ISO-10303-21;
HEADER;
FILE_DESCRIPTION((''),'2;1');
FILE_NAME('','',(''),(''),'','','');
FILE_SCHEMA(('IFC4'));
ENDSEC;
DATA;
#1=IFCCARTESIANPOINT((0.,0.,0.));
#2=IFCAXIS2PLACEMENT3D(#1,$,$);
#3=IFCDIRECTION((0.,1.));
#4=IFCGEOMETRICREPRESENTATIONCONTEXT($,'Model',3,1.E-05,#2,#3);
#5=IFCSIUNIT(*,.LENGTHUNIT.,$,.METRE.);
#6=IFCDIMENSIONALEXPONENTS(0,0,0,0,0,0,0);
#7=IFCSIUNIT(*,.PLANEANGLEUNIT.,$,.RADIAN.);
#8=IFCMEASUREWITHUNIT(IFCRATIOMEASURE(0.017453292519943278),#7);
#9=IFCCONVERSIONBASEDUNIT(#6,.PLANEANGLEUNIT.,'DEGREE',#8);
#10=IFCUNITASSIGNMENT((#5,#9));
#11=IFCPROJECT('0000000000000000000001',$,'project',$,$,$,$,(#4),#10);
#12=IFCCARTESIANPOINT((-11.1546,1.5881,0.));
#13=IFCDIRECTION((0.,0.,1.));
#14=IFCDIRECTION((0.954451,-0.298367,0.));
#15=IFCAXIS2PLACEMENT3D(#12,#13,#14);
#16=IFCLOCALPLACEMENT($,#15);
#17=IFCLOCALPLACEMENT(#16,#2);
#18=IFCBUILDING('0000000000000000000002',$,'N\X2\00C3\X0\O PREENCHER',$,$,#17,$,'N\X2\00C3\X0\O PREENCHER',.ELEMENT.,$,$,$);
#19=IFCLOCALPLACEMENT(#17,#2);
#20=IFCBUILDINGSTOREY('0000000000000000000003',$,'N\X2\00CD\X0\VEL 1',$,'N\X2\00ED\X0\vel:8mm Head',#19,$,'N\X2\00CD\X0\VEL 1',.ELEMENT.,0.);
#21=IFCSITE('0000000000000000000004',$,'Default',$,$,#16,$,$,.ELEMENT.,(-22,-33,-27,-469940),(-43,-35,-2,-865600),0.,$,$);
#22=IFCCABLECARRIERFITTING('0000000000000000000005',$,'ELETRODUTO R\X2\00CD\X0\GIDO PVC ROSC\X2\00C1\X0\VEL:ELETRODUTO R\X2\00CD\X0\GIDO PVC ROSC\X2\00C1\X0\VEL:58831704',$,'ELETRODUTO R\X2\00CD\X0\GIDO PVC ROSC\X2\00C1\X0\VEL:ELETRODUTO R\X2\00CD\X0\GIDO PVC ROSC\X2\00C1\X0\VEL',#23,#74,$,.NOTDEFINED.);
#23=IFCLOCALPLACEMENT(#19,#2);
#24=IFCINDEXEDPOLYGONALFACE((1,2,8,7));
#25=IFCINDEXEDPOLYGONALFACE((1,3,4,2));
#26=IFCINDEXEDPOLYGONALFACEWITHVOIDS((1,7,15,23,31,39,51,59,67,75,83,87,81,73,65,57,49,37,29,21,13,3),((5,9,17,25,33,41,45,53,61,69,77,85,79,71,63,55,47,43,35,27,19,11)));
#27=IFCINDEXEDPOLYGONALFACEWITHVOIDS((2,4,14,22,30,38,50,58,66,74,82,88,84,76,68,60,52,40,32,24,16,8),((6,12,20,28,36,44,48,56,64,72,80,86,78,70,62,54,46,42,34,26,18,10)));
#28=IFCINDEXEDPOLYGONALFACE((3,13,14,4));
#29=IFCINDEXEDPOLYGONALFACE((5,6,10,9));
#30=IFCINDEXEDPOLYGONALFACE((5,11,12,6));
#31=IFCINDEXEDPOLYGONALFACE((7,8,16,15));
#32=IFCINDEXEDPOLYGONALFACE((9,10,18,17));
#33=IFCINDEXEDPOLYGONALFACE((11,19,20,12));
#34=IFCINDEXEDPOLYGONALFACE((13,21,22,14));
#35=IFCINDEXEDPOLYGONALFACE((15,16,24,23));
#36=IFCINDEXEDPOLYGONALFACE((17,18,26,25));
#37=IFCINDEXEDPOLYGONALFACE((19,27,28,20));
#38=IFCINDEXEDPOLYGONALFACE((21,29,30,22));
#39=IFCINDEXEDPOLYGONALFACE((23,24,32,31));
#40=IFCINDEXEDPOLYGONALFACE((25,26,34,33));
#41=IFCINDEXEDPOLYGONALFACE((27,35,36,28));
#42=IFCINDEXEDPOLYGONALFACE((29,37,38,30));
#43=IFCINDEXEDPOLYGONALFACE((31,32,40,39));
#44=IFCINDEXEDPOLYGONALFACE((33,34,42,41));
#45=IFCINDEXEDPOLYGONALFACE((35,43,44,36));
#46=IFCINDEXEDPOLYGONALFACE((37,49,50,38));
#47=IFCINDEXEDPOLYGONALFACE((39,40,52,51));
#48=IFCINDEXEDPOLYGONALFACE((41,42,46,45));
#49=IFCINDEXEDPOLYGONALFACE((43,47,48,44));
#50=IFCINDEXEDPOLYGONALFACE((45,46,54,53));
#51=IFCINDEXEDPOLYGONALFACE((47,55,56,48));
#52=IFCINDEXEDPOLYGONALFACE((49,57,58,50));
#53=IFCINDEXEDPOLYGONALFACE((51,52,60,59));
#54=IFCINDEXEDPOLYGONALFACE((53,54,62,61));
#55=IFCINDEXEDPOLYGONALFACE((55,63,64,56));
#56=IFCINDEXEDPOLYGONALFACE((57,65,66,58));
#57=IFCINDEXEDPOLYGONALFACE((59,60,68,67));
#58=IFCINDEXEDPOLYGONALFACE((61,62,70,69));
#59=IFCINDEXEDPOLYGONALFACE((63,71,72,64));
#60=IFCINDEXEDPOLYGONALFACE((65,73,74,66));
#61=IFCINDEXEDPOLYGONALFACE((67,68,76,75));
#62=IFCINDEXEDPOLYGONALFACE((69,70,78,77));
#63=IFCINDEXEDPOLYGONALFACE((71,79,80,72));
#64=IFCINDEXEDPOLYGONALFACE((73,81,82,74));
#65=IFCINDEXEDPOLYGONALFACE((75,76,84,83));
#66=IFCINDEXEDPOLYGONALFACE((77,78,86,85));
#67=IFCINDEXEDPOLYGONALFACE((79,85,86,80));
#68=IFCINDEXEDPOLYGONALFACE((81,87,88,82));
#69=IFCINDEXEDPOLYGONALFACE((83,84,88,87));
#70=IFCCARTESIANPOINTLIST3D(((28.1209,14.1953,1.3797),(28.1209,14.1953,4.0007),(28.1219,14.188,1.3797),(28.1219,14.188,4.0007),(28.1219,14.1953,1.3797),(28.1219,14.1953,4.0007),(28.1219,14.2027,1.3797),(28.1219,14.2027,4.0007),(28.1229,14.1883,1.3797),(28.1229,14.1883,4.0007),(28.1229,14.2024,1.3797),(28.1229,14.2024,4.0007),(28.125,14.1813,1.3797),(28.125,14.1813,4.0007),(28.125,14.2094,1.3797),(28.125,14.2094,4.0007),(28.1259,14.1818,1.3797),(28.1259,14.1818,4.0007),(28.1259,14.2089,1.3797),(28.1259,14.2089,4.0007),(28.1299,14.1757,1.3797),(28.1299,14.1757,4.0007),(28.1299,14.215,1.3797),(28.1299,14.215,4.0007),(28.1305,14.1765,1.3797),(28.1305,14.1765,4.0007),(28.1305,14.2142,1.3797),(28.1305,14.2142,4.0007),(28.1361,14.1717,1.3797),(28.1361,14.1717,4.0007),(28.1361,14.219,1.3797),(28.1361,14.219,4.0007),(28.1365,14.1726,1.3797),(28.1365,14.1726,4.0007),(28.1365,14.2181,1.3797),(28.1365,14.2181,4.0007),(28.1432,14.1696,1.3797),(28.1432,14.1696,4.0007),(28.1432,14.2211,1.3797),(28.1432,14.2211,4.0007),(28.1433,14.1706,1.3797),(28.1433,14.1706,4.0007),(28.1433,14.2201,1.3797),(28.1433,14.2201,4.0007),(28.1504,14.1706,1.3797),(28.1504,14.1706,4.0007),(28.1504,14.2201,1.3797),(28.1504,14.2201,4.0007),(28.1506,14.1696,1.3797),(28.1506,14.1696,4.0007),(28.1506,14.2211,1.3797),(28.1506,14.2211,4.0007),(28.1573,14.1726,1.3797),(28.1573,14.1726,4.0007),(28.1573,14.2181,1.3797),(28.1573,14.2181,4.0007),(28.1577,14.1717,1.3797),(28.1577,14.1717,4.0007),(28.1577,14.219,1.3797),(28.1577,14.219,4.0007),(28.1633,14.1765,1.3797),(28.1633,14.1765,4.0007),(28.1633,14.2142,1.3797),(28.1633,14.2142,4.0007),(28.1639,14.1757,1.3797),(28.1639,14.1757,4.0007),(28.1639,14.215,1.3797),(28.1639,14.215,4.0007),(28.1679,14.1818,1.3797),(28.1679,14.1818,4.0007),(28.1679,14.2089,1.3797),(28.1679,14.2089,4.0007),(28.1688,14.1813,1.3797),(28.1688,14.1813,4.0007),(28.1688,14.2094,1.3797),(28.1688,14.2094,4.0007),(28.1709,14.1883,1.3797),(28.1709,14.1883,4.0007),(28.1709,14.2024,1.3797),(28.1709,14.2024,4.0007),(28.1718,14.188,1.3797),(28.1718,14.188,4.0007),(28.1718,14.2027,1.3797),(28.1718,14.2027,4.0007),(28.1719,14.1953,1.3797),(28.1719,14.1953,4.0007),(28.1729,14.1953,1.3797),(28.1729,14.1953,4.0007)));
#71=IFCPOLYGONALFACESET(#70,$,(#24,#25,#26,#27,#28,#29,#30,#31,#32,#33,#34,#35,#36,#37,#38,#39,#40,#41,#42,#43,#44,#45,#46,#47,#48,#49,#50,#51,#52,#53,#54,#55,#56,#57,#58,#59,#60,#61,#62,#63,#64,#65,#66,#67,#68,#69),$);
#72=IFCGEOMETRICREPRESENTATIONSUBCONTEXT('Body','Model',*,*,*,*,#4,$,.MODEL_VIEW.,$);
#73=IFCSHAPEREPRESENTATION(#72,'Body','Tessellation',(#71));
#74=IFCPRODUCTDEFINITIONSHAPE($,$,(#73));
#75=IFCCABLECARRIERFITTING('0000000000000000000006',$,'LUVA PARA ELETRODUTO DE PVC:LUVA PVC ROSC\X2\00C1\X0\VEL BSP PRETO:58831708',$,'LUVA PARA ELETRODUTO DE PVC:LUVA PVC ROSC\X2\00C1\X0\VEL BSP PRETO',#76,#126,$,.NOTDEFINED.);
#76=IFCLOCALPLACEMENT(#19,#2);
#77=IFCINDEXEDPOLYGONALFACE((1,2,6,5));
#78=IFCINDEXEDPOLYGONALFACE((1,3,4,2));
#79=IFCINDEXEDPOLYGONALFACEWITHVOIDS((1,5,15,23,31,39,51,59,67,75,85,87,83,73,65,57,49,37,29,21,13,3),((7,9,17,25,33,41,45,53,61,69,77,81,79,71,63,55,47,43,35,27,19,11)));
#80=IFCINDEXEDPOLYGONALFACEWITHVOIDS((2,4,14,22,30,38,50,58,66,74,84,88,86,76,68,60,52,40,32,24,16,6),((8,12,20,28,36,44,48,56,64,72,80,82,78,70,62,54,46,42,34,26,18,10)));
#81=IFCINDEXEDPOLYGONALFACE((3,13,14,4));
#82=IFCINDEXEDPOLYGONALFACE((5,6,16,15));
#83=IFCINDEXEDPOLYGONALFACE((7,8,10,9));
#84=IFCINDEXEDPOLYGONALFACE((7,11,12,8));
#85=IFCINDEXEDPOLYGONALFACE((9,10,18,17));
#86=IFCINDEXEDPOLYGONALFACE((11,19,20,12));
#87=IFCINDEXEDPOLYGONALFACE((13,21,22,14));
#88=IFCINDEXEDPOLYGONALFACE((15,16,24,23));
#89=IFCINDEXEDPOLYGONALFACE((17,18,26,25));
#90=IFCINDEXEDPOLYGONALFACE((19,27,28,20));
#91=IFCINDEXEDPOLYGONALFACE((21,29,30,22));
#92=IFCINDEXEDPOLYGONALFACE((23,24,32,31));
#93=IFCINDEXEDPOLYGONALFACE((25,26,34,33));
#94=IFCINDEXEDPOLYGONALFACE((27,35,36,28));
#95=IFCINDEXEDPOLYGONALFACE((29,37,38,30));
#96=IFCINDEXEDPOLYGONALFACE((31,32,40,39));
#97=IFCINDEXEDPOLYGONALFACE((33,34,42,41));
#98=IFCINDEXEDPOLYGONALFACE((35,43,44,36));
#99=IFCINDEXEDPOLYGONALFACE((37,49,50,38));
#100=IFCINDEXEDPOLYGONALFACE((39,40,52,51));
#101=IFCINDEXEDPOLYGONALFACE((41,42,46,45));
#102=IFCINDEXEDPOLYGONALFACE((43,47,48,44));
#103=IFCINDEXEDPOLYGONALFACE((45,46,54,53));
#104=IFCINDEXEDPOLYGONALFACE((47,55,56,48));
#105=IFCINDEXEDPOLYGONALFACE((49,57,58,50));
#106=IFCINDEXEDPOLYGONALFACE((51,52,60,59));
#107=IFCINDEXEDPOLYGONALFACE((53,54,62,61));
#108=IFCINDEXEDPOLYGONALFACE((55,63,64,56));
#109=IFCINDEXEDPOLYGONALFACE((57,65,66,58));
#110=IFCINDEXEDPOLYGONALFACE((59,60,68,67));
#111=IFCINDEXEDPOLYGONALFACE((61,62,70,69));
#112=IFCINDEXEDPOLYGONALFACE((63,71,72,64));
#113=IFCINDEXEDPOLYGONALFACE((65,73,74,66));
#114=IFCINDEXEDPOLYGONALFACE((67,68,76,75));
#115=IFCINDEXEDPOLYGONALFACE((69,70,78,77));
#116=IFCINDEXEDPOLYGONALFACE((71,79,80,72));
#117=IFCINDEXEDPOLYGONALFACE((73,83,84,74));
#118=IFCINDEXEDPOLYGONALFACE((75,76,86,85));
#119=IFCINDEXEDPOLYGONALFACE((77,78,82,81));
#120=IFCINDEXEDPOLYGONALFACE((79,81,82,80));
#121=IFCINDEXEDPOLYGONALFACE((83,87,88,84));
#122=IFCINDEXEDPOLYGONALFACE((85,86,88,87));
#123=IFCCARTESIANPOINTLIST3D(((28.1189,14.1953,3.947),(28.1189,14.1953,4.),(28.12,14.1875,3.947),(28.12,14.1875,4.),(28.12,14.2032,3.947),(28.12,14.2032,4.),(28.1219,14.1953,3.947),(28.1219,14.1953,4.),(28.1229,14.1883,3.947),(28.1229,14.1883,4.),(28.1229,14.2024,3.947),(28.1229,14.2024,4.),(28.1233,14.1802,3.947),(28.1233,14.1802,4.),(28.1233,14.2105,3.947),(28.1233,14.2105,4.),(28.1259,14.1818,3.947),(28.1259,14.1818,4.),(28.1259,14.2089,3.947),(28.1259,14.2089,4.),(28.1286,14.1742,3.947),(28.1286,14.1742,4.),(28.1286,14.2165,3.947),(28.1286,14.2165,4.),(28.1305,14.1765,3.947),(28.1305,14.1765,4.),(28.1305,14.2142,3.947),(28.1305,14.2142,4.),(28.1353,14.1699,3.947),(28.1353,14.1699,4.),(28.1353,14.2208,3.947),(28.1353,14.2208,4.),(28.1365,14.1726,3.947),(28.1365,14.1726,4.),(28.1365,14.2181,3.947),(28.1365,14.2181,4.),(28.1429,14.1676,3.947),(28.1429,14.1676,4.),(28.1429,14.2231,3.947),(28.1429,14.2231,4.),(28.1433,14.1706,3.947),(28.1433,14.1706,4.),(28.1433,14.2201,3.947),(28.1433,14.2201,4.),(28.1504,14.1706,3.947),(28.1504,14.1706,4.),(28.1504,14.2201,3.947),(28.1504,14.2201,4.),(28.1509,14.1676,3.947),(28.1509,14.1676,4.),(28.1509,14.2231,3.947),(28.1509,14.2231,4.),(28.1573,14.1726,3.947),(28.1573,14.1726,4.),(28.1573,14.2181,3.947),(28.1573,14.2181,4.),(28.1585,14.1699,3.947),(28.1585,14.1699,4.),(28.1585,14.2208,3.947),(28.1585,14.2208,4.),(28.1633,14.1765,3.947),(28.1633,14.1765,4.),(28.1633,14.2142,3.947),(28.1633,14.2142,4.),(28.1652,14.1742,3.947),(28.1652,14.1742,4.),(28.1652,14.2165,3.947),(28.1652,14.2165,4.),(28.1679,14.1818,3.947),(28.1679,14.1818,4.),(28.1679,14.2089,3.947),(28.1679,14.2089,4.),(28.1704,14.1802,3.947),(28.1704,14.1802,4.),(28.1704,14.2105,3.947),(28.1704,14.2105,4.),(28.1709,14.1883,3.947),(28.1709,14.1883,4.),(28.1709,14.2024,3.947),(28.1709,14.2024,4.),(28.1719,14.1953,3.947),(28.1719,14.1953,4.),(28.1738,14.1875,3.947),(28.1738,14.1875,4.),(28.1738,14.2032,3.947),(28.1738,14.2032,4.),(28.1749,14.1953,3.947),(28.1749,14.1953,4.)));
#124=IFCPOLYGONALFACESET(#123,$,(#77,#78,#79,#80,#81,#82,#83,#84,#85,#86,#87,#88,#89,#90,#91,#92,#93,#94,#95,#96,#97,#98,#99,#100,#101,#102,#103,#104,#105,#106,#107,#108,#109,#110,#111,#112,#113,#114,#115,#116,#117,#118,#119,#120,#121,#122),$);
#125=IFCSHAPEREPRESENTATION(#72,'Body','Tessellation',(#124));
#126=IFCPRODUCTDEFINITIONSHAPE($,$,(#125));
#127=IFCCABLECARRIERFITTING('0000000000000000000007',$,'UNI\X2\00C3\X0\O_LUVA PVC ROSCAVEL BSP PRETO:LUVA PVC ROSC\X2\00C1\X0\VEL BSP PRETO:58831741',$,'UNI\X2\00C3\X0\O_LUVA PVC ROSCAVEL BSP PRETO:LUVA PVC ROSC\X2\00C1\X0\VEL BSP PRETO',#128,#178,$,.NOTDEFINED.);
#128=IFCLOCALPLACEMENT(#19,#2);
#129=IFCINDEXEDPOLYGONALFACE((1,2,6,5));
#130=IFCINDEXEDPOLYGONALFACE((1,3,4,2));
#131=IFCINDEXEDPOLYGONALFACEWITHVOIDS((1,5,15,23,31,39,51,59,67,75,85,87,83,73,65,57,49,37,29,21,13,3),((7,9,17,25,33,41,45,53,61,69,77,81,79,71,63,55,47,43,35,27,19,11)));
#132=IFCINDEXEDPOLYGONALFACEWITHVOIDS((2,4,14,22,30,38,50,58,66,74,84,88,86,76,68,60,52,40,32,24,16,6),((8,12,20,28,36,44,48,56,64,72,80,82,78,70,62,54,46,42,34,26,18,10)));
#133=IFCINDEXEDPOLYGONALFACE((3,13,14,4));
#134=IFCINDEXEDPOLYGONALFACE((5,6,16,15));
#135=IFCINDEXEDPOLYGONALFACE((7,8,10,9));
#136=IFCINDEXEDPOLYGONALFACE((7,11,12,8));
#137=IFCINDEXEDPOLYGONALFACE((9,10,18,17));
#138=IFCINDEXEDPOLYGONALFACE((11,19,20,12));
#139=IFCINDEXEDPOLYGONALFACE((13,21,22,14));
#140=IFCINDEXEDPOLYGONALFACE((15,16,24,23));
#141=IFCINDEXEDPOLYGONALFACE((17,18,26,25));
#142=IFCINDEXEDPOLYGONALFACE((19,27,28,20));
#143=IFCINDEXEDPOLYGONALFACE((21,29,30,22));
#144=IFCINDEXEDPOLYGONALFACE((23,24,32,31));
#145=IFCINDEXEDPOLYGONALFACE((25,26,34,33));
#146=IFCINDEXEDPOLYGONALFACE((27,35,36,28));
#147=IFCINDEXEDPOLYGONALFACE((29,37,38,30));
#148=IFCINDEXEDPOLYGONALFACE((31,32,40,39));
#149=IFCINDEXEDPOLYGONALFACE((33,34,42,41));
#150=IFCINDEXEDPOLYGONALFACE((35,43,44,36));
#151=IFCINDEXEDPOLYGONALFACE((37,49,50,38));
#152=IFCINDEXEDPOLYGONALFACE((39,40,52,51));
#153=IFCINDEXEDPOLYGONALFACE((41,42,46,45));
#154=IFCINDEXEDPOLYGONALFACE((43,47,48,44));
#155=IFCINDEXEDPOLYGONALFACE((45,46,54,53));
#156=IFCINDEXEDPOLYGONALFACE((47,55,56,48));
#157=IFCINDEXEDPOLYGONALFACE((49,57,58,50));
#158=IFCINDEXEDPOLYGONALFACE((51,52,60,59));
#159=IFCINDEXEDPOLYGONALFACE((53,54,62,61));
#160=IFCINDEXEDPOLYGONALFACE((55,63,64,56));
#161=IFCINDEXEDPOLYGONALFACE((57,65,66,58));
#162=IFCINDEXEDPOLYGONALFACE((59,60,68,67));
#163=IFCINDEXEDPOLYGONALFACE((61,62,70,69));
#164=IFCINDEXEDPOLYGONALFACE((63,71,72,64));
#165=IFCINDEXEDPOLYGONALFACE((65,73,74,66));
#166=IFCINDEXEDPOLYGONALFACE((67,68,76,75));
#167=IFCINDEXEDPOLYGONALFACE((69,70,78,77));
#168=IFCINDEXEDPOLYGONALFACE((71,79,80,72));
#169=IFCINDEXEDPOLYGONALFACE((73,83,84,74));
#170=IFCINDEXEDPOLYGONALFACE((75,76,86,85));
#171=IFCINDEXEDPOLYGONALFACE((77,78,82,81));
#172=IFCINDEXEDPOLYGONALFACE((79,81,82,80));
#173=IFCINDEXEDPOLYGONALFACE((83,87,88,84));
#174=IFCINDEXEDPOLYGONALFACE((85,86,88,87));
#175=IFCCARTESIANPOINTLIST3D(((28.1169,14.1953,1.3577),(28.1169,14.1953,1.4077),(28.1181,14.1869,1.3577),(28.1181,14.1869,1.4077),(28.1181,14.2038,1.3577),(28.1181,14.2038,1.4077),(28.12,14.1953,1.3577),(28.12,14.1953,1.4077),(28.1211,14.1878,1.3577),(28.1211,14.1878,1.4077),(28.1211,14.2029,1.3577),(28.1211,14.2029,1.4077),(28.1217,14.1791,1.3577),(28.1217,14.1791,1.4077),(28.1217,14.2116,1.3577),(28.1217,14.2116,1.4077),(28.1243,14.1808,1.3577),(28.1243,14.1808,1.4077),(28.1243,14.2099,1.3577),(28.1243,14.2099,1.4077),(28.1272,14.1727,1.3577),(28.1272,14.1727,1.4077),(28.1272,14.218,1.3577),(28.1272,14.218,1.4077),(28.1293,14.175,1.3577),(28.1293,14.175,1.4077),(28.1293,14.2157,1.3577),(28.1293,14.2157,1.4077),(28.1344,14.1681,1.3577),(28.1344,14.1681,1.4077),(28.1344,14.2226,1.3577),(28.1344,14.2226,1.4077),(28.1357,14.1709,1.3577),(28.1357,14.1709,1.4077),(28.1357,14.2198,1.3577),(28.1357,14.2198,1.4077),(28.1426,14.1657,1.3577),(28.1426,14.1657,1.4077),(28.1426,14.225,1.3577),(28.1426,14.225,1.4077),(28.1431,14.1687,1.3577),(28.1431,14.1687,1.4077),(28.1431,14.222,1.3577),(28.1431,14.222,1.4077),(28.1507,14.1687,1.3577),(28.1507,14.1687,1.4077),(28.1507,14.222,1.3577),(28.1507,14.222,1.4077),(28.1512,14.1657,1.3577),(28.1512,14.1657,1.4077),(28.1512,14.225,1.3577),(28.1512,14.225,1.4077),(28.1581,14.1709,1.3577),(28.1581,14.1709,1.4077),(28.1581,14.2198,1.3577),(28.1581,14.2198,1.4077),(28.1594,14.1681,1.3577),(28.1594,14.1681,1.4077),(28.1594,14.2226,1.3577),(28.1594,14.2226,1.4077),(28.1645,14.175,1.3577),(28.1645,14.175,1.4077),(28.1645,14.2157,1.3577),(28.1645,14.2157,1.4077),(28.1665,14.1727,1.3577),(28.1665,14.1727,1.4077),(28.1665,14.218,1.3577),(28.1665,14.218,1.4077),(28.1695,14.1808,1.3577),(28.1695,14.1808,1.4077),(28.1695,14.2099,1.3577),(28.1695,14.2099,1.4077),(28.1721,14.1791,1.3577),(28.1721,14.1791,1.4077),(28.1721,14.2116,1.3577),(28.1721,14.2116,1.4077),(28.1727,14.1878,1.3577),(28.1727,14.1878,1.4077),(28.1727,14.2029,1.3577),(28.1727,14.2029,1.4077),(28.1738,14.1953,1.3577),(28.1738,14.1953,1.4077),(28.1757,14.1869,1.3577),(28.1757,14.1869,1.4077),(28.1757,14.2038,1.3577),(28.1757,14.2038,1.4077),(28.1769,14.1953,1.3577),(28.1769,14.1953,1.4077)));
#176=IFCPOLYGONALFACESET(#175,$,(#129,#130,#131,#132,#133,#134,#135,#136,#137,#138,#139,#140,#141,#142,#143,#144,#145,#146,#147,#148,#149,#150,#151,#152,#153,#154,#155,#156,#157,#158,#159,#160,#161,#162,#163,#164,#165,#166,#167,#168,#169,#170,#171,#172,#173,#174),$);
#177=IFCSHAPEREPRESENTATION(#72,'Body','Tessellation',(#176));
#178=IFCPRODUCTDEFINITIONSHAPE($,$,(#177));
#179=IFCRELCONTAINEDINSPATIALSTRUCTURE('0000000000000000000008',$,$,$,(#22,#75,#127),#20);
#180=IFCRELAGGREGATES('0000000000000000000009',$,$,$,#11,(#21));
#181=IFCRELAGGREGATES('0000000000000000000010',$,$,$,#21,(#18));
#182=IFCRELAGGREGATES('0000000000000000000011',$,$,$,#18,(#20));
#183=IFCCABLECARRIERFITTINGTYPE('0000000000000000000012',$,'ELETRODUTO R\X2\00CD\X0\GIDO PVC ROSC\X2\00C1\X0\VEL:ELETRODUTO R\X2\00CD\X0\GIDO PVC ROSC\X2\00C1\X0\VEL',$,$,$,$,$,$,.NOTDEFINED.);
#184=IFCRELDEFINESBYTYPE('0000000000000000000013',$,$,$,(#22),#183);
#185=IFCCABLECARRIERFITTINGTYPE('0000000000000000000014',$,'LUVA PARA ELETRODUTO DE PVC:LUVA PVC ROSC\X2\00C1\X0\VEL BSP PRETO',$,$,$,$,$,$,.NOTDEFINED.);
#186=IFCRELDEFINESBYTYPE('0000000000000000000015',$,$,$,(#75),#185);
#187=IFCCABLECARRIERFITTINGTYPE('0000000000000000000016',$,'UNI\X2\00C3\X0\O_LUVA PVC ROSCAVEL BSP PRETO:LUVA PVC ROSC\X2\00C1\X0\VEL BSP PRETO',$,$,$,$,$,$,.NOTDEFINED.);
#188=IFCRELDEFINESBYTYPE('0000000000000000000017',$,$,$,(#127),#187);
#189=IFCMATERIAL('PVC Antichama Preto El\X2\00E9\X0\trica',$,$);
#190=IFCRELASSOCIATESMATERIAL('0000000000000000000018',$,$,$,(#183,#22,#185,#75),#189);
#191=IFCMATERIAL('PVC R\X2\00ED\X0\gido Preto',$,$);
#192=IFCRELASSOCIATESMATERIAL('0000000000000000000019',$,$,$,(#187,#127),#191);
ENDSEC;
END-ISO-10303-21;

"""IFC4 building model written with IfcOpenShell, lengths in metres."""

from ifc_helpers import new_model, entity, si_unit, converted_unit, direction, frame, origin, place, context, subcontext, project, spatial, arc, indexed_curve, outline, extrude, source, transform, mapped, material, type_object, type_shapes, element, save


model = new_model("IFC4")

# Units and contexts
model_context = context("Model", 3, precision=1e-05, world=origin(), true_north=direction((0.0, 1.0)))
body_context = subcontext(model_context, "Body", "Model", "MODEL_VIEW")
ifc_project = project(units=[si_unit("LENGTHUNIT", "METRE"), converted_unit("PLANEANGLEUNIT", "DEGREE", entity("IfcRatioMeasure", 0.017453292519943278), si_unit("PLANEANGLEUNIT", "RADIAN"), dimensions=[0, 0, 0, 0, 0, 0, 0])], contexts=[model_context])

# Site, building, storey
site_placement = place(None, frame((-11.1546, 1.5881, 0.0), z_axis=(0.0, 0.0, 1.0), x_axis=(0.954451, -0.298367, 0.0)))
site = spatial("IfcSite", under=ifc_project, at=site_placement, Name="Default", CompositionType="ELEMENT", RefLatitude=(-22, -33, -27, -469940), RefLongitude=(-43, -35, -2, -865600), RefElevation=0.0)
building_placement = place(site_placement, origin())
building = spatial("IfcBuilding", under=site, at=building_placement, Name="NÃO PREENCHER", LongName="NÃO PREENCHER", CompositionType="ELEMENT")
storey_placement = place(building_placement, origin())
storey = spatial("IfcBuildingStorey", under=building, at=storey_placement, Name="NÍVEL 1", ObjectType="Nível:8mm Head", LongName="NÍVEL 1", CompositionType="ELEMENT", Elevation=0.0)

# Cable carrier fittings
ifc_material_1 = material(Name="PVC Antichama Preto Elétrica")
cable_carrier_fitting_type_1 = type_object("IfcCableCarrierFittingType", Name="ELETRODUTO RÍGIDO PVC ROSCÁVEL:ELETRODUTO RÍGIDO PVC ROSCÁVEL", PredefinedType="NOTDEFINED", material=ifc_material_1)
shared_shape_1 = source(origin(), body_context, "Body", "SweptSolid", [
    extrude(outline(indexed_curve([(0.0, 0.026), (-0.026, 0.0), (0.0, -0.026), (0.026, 0.0)], segments=[arc(1, 2, 3), arc(3, 4, 1)], self_intersect=False), holes=[indexed_curve([(0.0, 0.025), (0.025, 0.0), (0.0, -0.025), (-0.025, 0.0)], segments=[arc(1, 2, 3), arc(3, 4, 1)], self_intersect=False)]), frame((0.0, 0.0, 0.0), z_axis=(0.0, 0.0, 1.0), x_axis=(-1.0, 0.0, 0.0)), (0.0, 0.0, 1.0), 2.621),
])
type_shapes(cable_carrier_fitting_type_1, [shared_shape_1])
cable_carrier_fitting_1_placement = place(storey_placement, frame((28.1469, 14.1953, 1.3797), z_axis=(0.0, 0.0, 1.0), x_axis=(0.0, 1.0, 0.0)))
element("IfcCableCarrierFitting", 1, at=cable_carrier_fitting_1_placement, inside=storey, type_object=cable_carrier_fitting_type_1, material=ifc_material_1, Name="ELETRODUTO RÍGIDO PVC ROSCÁVEL:ELETRODUTO RÍGIDO PVC ROSCÁVEL:58831704", ObjectType="ELETRODUTO RÍGIDO PVC ROSCÁVEL:ELETRODUTO RÍGIDO PVC ROSCÁVEL", PredefinedType="NOTDEFINED", context=body_context, shape_type="MappedRepresentation", body=[
    mapped(shared_shape_1, transform((0.0, 0.0, 0.0), scale=1.0)),
])
cable_carrier_fitting_type_2 = type_object("IfcCableCarrierFittingType", Name="LUVA PARA ELETRODUTO DE PVC:LUVA PVC ROSCÁVEL BSP PRETO", PredefinedType="NOTDEFINED", material=ifc_material_1)
shared_shape_2 = source(origin(), body_context, "Body", "SweptSolid", [
    extrude(outline(indexed_curve([(-0.028, 0.0), (0.0, -0.028), (0.028, 0.0), (0.0, 0.028)], segments=[arc(1, 2, 3), arc(3, 4, 1)], self_intersect=False), holes=[indexed_curve([(-0.025, 0.0), (0.0, 0.025), (0.025, 0.0), (0.0, -0.025)], segments=[arc(1, 2, 3), arc(3, 4, 1)], self_intersect=False)]), frame((0.0, 0.0, -0.0265), z_axis=(0.0, 0.0, 1.0), x_axis=(0.0, 1.0, 0.0)), (0.0, 0.0, 1.0), 0.053),
])
type_shapes(cable_carrier_fitting_type_2, [shared_shape_2])
cable_carrier_fitting_2_placement = place(storey_placement, frame((28.1469, 14.1953, 3.9735), z_axis=(0.0, 0.0, 1.0), x_axis=(0.0, 1.0, 0.0)))
element("IfcCableCarrierFitting", 2, at=cable_carrier_fitting_2_placement, inside=storey, type_object=cable_carrier_fitting_type_2, material=ifc_material_1, Name="LUVA PARA ELETRODUTO DE PVC:LUVA PVC ROSCÁVEL BSP PRETO:58831708", ObjectType="LUVA PARA ELETRODUTO DE PVC:LUVA PVC ROSCÁVEL BSP PRETO", PredefinedType="NOTDEFINED", context=body_context, shape_type="MappedRepresentation", body=[
    mapped(shared_shape_2, transform((0.0, 0.0, 0.0), scale=1.0)),
])
ifc_material_2 = material(Name="PVC Rígido Preto")
cable_carrier_fitting_type_3 = type_object("IfcCableCarrierFittingType", Name="UNIÃO_LUVA PVC ROSCAVEL BSP PRETO:LUVA PVC ROSCÁVEL BSP PRETO", PredefinedType="NOTDEFINED", material=ifc_material_2)
shared_shape_3 = source(origin(), body_context, "Body", "SweptSolid", [
    extrude(outline(indexed_curve([(-0.03, 0.0), (0.0, -0.03), (0.03, 0.0), (0.0, 0.03)], segments=[arc(1, 2, 3), arc(3, 4, 1)], self_intersect=False), holes=[indexed_curve([(-0.0269, 0.0), (0.0, 0.0269), (0.0269, 0.0), (0.0, -0.0269)], segments=[arc(1, 2, 3), arc(3, 4, 1)], self_intersect=False)]), frame((-0.025, 0.0, 0.0), z_axis=(1.0, 0.0, 0.0), x_axis=(0.0, 0.0, -1.0)), (0.0, 0.0, 1.0), 0.05),
])
type_shapes(cable_carrier_fitting_type_3, [shared_shape_3])
cable_carrier_fitting_3_placement = place(storey_placement, frame((28.1469, 14.1953, 1.3827), z_axis=(-1.0, 0.0, 0.0), x_axis=(0.0, 0.0, -1.0)))
element("IfcCableCarrierFitting", 3, at=cable_carrier_fitting_3_placement, inside=storey, type_object=cable_carrier_fitting_type_3, material=ifc_material_2, Name="UNIÃO_LUVA PVC ROSCAVEL BSP PRETO:LUVA PVC ROSCÁVEL BSP PRETO:58831741", ObjectType="UNIÃO_LUVA PVC ROSCAVEL BSP PRETO:LUVA PVC ROSCÁVEL BSP PRETO", PredefinedType="NOTDEFINED", context=body_context, shape_type="MappedRepresentation", body=[
    mapped(shared_shape_3, transform((0.0, 0.0, 0.0), scale=1.0)),
])

save(model, "model.ifc")
